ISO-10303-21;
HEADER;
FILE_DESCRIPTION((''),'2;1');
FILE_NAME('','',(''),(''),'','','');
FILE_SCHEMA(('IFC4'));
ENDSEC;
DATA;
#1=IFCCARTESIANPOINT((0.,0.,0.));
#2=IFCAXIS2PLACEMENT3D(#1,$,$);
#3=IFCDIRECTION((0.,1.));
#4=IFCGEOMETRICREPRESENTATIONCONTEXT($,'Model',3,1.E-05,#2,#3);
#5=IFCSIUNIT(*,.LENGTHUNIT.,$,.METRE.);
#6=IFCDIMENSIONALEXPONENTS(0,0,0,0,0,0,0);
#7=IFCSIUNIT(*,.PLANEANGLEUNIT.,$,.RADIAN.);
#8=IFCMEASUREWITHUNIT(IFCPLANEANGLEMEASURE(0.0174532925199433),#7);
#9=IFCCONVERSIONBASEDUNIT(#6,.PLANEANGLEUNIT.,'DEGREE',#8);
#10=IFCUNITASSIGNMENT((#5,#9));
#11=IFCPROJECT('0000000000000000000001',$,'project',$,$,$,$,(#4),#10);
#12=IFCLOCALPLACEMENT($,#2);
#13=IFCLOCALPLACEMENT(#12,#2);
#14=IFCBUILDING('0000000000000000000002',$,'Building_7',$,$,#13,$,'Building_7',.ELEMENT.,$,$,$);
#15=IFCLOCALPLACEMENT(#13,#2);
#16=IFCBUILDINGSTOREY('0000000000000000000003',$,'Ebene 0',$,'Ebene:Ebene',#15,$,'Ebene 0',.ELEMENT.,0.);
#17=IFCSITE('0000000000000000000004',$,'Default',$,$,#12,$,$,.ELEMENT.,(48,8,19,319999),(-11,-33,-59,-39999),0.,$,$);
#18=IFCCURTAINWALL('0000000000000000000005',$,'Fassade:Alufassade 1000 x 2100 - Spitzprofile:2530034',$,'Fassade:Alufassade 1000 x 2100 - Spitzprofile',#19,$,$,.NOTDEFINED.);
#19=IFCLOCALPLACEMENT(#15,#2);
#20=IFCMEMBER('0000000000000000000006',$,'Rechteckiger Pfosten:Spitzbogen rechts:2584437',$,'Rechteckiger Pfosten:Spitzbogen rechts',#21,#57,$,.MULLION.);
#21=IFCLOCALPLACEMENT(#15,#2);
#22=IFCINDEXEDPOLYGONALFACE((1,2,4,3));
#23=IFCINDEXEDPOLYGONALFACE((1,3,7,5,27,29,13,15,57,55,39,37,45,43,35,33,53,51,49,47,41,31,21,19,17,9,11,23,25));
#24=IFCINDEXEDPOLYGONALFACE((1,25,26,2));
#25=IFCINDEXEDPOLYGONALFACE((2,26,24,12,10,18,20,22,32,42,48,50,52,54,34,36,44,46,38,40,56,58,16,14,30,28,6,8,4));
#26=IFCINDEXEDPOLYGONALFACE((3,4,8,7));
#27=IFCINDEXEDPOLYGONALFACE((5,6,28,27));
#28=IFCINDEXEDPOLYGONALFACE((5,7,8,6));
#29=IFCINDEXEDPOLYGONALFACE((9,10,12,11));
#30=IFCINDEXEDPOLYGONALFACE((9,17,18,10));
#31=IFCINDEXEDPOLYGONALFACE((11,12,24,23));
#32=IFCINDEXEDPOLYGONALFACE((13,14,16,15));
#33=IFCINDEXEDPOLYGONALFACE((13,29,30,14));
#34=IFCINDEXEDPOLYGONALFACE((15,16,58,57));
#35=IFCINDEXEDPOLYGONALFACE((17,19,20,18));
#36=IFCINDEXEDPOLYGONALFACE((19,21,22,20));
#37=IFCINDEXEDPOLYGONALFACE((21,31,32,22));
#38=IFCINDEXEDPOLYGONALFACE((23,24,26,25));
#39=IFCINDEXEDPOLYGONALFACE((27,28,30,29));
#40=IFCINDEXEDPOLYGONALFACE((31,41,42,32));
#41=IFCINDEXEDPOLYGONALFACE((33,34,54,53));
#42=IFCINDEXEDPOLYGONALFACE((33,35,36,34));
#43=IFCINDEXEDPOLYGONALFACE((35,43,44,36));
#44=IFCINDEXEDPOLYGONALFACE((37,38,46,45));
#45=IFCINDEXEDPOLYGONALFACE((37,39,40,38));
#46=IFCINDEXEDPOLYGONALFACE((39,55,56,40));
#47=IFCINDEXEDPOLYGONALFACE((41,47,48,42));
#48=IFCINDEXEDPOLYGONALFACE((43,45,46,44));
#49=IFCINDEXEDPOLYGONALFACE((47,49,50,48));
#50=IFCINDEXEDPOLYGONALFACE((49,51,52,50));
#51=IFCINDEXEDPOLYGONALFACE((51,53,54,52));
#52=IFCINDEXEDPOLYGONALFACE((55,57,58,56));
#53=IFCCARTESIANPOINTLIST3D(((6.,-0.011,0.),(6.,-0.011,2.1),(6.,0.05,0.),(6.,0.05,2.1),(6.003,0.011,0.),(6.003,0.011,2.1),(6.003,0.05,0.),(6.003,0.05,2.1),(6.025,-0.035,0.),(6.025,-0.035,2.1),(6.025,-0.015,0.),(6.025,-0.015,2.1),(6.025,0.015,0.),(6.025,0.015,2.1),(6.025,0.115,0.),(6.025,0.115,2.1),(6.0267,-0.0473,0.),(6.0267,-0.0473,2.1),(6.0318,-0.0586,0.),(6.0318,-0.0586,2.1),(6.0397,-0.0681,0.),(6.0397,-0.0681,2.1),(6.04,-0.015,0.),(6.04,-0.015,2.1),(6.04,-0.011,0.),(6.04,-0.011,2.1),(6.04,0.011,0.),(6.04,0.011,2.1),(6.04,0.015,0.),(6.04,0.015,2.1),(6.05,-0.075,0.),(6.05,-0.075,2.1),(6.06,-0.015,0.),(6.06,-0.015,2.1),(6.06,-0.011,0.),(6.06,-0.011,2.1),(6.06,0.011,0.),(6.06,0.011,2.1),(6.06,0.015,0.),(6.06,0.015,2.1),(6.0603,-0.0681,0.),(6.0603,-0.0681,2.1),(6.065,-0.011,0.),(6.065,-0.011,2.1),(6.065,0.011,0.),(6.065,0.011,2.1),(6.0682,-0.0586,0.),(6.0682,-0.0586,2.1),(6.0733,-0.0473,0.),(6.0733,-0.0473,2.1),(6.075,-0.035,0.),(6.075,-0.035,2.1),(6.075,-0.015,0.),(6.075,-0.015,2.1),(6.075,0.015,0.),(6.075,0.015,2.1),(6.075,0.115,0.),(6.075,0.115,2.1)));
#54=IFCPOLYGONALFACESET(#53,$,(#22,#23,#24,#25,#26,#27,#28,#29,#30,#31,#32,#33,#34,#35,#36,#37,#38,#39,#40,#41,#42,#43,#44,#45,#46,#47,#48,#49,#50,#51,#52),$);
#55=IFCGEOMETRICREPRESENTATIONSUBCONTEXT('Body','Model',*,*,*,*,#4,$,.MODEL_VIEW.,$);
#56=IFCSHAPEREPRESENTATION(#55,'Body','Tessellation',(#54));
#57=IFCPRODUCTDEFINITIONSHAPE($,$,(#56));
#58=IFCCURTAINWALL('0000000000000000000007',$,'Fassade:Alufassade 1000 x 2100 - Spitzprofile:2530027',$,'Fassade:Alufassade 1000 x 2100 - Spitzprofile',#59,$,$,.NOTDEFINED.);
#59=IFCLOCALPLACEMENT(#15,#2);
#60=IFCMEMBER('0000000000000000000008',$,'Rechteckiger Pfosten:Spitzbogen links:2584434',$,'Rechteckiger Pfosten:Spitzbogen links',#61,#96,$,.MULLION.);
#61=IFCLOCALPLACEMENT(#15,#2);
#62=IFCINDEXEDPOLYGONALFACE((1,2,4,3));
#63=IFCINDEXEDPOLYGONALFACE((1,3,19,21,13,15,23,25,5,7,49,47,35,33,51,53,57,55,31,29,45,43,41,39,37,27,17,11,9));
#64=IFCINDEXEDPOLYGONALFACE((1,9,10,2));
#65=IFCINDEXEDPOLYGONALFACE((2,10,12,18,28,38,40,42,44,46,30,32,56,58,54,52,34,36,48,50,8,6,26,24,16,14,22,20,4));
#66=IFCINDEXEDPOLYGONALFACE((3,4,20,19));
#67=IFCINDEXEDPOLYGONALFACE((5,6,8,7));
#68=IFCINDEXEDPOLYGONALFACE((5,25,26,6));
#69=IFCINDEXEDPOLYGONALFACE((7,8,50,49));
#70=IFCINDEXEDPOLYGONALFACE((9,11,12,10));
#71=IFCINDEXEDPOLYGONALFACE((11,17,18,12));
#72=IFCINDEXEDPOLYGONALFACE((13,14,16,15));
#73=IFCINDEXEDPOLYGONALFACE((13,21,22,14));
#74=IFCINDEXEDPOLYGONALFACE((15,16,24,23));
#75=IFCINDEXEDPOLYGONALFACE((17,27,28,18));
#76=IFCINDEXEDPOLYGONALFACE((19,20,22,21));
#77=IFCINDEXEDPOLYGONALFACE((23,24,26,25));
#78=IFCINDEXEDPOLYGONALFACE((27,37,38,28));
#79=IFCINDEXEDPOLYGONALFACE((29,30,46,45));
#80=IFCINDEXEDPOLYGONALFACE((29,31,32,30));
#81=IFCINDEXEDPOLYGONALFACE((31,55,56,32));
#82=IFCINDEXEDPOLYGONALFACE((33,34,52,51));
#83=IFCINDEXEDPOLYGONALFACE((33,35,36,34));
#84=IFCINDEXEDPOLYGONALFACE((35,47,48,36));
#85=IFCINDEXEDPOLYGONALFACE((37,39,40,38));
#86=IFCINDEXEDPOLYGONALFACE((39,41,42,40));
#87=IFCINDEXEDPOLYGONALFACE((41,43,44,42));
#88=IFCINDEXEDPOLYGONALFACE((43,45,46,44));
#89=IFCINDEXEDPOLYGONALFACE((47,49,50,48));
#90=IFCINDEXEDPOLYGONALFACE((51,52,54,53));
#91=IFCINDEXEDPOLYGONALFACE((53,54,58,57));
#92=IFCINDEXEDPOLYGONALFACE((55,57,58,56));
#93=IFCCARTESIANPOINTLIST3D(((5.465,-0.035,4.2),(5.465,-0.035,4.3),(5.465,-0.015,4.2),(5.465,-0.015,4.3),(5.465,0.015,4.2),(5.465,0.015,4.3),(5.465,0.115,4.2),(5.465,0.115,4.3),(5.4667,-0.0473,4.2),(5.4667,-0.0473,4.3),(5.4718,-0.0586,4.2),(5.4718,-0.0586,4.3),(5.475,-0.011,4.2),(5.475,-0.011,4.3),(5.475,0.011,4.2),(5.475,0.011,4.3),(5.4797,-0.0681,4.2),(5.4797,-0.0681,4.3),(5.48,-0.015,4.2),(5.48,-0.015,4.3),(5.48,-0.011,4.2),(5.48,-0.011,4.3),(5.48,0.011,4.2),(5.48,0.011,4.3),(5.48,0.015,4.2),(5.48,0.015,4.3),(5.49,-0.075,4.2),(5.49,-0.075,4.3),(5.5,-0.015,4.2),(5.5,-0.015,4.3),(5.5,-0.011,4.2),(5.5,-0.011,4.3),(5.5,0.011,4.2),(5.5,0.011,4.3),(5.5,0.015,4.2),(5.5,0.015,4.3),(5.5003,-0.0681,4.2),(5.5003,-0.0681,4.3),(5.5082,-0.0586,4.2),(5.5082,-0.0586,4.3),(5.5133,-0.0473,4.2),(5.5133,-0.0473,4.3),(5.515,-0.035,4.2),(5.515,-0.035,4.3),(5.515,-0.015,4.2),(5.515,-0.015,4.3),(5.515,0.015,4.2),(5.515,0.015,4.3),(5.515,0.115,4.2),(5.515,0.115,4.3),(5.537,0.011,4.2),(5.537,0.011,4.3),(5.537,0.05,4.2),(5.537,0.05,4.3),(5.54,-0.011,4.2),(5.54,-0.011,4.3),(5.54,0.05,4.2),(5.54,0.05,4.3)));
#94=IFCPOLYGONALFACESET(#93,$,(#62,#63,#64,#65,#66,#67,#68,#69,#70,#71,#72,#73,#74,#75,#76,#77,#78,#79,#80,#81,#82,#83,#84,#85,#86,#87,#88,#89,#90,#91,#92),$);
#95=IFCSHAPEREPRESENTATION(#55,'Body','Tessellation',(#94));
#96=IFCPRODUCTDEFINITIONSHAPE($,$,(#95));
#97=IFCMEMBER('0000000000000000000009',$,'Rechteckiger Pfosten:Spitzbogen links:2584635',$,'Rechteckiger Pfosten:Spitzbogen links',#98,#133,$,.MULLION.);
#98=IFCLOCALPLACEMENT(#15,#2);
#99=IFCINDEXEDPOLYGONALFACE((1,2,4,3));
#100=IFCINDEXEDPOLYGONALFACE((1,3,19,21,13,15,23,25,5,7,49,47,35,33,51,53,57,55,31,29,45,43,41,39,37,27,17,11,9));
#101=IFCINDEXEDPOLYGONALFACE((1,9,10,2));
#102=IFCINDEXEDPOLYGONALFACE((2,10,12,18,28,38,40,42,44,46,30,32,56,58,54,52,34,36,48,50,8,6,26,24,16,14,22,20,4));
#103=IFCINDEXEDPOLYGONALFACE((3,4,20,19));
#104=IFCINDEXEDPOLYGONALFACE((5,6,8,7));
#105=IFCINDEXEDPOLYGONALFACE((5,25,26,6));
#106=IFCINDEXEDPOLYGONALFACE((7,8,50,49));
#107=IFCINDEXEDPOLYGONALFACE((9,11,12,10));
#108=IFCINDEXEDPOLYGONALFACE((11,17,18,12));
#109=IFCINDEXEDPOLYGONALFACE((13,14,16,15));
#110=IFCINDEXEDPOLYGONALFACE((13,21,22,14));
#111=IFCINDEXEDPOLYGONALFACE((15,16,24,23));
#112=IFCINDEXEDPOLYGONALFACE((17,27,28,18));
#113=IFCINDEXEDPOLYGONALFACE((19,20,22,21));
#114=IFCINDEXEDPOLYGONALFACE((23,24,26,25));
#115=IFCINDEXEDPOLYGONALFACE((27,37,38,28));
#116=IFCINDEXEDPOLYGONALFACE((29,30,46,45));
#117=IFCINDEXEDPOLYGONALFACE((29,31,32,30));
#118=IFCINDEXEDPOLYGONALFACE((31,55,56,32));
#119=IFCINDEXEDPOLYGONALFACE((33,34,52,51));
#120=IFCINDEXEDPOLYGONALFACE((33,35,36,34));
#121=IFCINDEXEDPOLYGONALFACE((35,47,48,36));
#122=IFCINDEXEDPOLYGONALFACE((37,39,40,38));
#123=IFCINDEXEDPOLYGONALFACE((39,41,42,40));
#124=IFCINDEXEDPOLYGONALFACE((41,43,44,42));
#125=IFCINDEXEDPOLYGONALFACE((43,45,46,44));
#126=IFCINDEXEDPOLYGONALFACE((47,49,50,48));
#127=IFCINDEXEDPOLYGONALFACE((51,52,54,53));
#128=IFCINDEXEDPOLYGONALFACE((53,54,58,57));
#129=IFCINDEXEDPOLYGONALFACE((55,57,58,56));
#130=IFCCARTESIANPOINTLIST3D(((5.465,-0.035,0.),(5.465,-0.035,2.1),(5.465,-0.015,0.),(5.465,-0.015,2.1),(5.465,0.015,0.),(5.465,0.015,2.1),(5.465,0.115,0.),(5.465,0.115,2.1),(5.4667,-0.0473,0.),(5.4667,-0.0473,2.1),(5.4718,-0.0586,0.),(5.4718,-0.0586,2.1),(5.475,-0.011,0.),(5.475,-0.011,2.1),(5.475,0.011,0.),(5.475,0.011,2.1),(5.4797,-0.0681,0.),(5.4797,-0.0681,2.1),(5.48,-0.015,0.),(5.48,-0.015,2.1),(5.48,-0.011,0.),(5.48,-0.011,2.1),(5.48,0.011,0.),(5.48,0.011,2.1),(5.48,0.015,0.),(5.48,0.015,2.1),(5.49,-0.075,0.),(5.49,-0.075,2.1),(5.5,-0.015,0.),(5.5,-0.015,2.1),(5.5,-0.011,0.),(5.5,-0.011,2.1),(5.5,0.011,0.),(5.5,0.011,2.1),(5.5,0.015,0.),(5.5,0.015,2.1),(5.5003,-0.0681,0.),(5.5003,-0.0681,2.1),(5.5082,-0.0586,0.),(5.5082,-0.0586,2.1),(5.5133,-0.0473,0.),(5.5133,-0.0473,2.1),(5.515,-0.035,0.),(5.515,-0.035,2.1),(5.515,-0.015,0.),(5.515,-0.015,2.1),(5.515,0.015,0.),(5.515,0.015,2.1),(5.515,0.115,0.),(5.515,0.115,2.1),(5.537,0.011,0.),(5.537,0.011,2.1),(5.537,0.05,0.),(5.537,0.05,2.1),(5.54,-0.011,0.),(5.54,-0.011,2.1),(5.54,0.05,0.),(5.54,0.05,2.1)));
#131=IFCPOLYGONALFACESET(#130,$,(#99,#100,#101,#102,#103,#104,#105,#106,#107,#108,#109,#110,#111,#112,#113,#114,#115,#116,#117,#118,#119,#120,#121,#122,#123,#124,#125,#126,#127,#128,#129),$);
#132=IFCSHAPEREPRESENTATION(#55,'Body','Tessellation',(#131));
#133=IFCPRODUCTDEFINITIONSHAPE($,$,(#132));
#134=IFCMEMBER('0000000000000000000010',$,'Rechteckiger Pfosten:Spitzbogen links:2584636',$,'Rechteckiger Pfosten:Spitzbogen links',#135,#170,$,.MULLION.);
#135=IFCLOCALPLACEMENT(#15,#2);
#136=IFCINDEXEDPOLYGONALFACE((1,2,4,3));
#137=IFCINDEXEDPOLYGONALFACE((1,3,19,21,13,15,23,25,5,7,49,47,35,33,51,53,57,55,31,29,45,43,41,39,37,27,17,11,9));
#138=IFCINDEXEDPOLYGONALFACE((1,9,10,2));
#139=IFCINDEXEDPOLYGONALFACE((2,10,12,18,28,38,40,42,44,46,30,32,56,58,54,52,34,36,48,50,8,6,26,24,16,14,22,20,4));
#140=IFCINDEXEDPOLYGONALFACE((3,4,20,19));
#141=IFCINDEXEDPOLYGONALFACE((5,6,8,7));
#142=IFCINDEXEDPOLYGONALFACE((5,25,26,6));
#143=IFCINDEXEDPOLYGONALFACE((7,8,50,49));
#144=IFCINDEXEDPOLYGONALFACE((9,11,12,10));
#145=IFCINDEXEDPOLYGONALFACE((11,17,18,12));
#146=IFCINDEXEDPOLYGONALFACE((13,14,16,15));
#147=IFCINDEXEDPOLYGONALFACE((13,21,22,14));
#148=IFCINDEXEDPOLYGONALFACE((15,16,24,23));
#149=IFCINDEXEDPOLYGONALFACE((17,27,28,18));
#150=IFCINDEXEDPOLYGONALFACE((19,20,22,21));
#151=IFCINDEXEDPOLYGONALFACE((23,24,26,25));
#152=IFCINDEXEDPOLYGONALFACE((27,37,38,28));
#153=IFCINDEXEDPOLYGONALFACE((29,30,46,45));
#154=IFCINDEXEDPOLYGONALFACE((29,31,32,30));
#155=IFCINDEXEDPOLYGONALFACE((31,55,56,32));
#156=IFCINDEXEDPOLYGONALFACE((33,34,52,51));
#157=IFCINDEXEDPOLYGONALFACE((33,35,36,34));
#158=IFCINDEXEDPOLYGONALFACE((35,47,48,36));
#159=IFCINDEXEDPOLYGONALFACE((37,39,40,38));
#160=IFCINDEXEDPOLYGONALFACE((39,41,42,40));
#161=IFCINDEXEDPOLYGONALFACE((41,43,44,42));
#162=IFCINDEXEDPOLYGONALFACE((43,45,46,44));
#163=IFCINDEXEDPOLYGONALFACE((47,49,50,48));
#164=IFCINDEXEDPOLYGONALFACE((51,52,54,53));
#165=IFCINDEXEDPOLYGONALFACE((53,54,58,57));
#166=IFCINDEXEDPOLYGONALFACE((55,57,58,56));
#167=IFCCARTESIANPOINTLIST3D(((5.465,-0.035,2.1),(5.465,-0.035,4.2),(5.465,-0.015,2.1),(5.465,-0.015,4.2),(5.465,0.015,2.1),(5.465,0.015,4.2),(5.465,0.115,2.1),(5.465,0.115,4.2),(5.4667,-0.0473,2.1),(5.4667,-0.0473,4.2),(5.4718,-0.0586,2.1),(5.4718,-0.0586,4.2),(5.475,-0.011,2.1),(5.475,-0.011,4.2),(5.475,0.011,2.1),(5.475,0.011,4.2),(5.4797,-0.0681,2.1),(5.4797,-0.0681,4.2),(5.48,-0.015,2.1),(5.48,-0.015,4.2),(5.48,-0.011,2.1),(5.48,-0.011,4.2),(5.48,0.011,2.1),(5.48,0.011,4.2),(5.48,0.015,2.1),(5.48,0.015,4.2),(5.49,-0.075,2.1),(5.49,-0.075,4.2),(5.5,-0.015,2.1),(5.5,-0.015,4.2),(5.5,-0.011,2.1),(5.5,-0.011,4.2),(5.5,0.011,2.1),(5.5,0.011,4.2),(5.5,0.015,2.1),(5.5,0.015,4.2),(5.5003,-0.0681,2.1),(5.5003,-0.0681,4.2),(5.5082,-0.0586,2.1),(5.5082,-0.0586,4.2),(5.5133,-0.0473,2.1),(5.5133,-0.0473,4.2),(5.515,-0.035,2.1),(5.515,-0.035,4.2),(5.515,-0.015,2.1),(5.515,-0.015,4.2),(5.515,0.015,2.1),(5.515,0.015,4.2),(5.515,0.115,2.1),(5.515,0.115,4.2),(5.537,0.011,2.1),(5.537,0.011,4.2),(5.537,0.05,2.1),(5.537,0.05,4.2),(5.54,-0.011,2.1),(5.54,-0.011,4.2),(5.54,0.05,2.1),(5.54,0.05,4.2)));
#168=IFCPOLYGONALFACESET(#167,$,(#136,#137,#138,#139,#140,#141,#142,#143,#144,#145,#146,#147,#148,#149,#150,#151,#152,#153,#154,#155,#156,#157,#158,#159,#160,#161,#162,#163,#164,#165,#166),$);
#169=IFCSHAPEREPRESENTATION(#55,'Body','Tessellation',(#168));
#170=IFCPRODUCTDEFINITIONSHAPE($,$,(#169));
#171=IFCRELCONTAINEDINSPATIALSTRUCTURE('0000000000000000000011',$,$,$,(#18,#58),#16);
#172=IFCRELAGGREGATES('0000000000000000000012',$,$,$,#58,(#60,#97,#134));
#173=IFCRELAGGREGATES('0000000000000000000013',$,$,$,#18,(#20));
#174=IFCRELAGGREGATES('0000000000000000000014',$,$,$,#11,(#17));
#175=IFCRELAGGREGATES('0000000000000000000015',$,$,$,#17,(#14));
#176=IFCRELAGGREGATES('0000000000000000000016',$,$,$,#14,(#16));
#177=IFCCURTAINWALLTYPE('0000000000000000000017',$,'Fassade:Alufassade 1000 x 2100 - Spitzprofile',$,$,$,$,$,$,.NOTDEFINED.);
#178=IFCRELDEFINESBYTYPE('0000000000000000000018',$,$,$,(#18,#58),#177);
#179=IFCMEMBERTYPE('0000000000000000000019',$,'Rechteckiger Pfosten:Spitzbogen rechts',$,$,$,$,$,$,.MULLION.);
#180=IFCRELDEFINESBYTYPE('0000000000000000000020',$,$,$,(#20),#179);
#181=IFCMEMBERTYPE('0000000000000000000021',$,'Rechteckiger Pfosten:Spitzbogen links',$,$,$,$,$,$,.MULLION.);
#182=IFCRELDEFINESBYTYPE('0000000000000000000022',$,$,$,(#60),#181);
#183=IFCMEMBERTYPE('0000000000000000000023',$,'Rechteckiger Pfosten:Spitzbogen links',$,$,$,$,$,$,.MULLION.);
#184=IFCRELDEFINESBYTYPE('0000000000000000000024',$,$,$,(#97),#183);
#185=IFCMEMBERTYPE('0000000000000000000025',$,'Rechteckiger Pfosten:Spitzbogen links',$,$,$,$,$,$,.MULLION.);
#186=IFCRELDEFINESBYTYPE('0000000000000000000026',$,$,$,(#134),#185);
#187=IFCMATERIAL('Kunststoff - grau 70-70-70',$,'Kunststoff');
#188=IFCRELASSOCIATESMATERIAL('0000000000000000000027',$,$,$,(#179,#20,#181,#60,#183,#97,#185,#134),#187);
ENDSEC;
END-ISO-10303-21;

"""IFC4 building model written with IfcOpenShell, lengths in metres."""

from ifc_helpers import new_model, entity, si_unit, converted_unit, direction, frame, origin, place, context, subcontext, project, spatial, line, arc, indexed_curve, outline, extrude, source, transform, mapped, material, type_object, type_shapes, element, aggregate, save


model = new_model("IFC4")

# Units and contexts
model_context = context("Model", 3, precision=1e-05, world=origin(), true_north=direction((0.0, 1.0)))
body_context = subcontext(model_context, "Body", "Model", "MODEL_VIEW")
ifc_project = project(units=[si_unit("LENGTHUNIT", "METRE"), converted_unit("PLANEANGLEUNIT", "DEGREE", entity("IfcPlaneAngleMeasure", 0.0174532925199433), si_unit("PLANEANGLEUNIT", "RADIAN"), dimensions=[0, 0, 0, 0, 0, 0, 0])], contexts=[model_context])

# Site, building, storey
site_placement = place(None, origin())
site = spatial("IfcSite", under=ifc_project, at=site_placement, Name="Default", CompositionType="ELEMENT", RefLatitude=(48, 8, 19, 319999), RefLongitude=(-11, -33, -59, -39999), RefElevation=0.0)
building_placement = place(site_placement, origin())
building = spatial("IfcBuilding", under=site, at=building_placement, Name="Building_7", LongName="Building_7", CompositionType="ELEMENT")
storey_placement = place(building_placement, origin())
storey = spatial("IfcBuildingStorey", under=building, at=storey_placement, Name="Ebene 0", ObjectType="Ebene:Ebene", LongName="Ebene 0", CompositionType="ELEMENT", Elevation=0.0)

# Curtain wall, member
curtain_wall_type = type_object("IfcCurtainWallType", Name="Fassade:Alufassade 1000 x 2100 - Spitzprofile", PredefinedType="NOTDEFINED")
curtain_wall_1_placement = place(storey_placement, origin())
curtain_wall_1 = element("IfcCurtainWall", 1, at=curtain_wall_1_placement, inside=storey, type_object=curtain_wall_type, Name="Fassade:Alufassade 1000 x 2100 - Spitzprofile:2530034", ObjectType="Fassade:Alufassade 1000 x 2100 - Spitzprofile", PredefinedType="NOTDEFINED")
ifc_material_1 = material(Name="Kunststoff - grau 70-70-70", Category="Kunststoff")
member_type_1 = type_object("IfcMemberType", Name="Rechteckiger Pfosten:Spitzbogen rechts", PredefinedType="MULLION", material=ifc_material_1)
shared_shape_1 = source(origin(), body_context, "Body", "SweptSolid", [
    extrude(outline(indexed_curve([(-0.107, -0.0321), (-0.007, -0.0321), (-0.007, -0.0171), (-0.003, -0.0171), (-0.003, -0.0221), (0.019, -0.0221), (0.019, -0.0171), (0.023, -0.0171), (0.023, -0.0321), (0.043, -0.0321), (0.0666, -0.0254), (0.083, -0.0071), (0.0666, 0.0111), (0.043, 0.0179), (0.023, 0.0179), (0.023, 0.0029), (0.019, 0.0029), (0.019, 0.0429), (-0.042, 0.0429), (-0.042, 0.0399), (-0.003, 0.0399), (-0.003, 0.0029), (-0.007, 0.0029), (-0.007, 0.0179), (-0.107, 0.0179)], segments=[line(1, 2, 3, 4, 5, 6, 7, 8, 9, 10), arc(10, 11, 12), arc(12, 13, 14), line(14, 15, 16, 17, 18, 19, 20, 21, 22, 23, 24, 25, 1)], self_intersect=False)), frame((-0.0429, 0.008, -2.1), z_axis=(0.0, 0.0, 1.0), x_axis=(0.0, -1.0, 0.0)), (0.0, 0.0, 1.0), 2.1),
])
type_shapes(member_type_1, [shared_shape_1])
member_1_placement = place(curtain_wall_1_placement, frame((6.0, 0.0, 0.0), z_axis=(0.0, 0.0, -1.0), x_axis=(-1.0, 0.0, 0.0)))
member_1 = element("IfcMember", 2, at=member_1_placement, type_object=member_type_1, material=ifc_material_1, Name="Rechteckiger Pfosten:Spitzbogen rechts:2584437", ObjectType="Rechteckiger Pfosten:Spitzbogen rechts", PredefinedType="MULLION", context=body_context, shape_type="MappedRepresentation", body=[
    mapped(shared_shape_1, transform((0.0, 0.0, 0.0), scale=1.0)),
])

# Curtain wall, members
curtain_wall_2_placement = place(storey_placement, origin())
curtain_wall_2 = element("IfcCurtainWall", 3, at=curtain_wall_2_placement, inside=storey, type_object=curtain_wall_type, Name="Fassade:Alufassade 1000 x 2100 - Spitzprofile:2530027", ObjectType="Fassade:Alufassade 1000 x 2100 - Spitzprofile", PredefinedType="NOTDEFINED")
member_type_2 = type_object("IfcMemberType", Name="Rechteckiger Pfosten:Spitzbogen links", PredefinedType="MULLION", material=ifc_material_1)
shared_shape_2 = source(origin(), body_context, "Body", "SweptSolid", [
    extrude(outline(indexed_curve([(-0.107, -0.0321), (-0.007, -0.0321), (-0.007, -0.0171), (-0.003, -0.0171), (-0.003, -0.0221), (0.019, -0.0221), (0.019, -0.0171), (0.023, -0.0171), (0.023, -0.0321), (0.043, -0.0321), (0.0666, -0.0254), (0.083, -0.0071), (0.0666, 0.0111), (0.043, 0.0179), (0.023, 0.0179), (0.023, 0.0029), (0.019, 0.0029), (0.019, 0.0429), (-0.042, 0.0429), (-0.042, 0.0399), (-0.003, 0.0399), (-0.003, 0.0029), (-0.007, 0.0029), (-0.007, 0.0179), (-0.107, 0.0179)], segments=[line(1, 2, 3, 4, 5, 6, 7, 8, 9, 10), arc(10, 11, 12), arc(12, 13, 14), line(14, 15, 16, 17, 18, 19, 20, 21, 22, 23, 24, 25, 1)], self_intersect=False)), frame((-0.0429, 0.008, -0.1), z_axis=(0.0, 0.0, 1.0), x_axis=(0.0, -1.0, 0.0)), (0.0, 0.0, 1.0), 0.1),
])
type_shapes(member_type_2, [shared_shape_2])
member_2_placement = place(curtain_wall_2_placement, frame((5.54, 0.0, 4.3)))
member_2 = element("IfcMember", 4, at=member_2_placement, type_object=member_type_2, material=ifc_material_1, Name="Rechteckiger Pfosten:Spitzbogen links:2584434", ObjectType="Rechteckiger Pfosten:Spitzbogen links", PredefinedType="MULLION", context=body_context, shape_type="MappedRepresentation", body=[
    mapped(shared_shape_2, transform((0.0, 0.0, 0.0), scale=1.0)),
])
member_type_3 = type_object("IfcMemberType", Name="Rechteckiger Pfosten:Spitzbogen links", PredefinedType="MULLION", material=ifc_material_1)
shared_shape_3 = source(origin(), body_context, "Body", "SweptSolid", [
    extrude(outline(indexed_curve([(-0.107, -0.0321), (-0.007, -0.0321), (-0.007, -0.0171), (-0.003, -0.0171), (-0.003, -0.0221), (0.019, -0.0221), (0.019, -0.0171), (0.023, -0.0171), (0.023, -0.0321), (0.043, -0.0321), (0.0666, -0.0254), (0.083, -0.0071), (0.0666, 0.0111), (0.043, 0.0179), (0.023, 0.0179), (0.023, 0.0029), (0.019, 0.0029), (0.019, 0.0429), (-0.042, 0.0429), (-0.042, 0.0399), (-0.003, 0.0399), (-0.003, 0.0029), (-0.007, 0.0029), (-0.007, 0.0179), (-0.107, 0.0179)], segments=[line(1, 2, 3, 4, 5, 6, 7, 8, 9, 10), arc(10, 11, 12), arc(12, 13, 14), line(14, 15, 16, 17, 18, 19, 20, 21, 22, 23, 24, 25, 1)], self_intersect=False)), frame((-0.0429, 0.008, -2.1), z_axis=(0.0, 0.0, 1.0), x_axis=(0.0, -1.0, 0.0)), (0.0, 0.0, 1.0), 2.1),
])
type_shapes(member_type_3, [shared_shape_3])
member_3_placement = place(curtain_wall_2_placement, frame((5.54, 0.0, 2.1)))
member_3 = element("IfcMember", 5, at=member_3_placement, type_object=member_type_3, material=ifc_material_1, Name="Rechteckiger Pfosten:Spitzbogen links:2584635", ObjectType="Rechteckiger Pfosten:Spitzbogen links", PredefinedType="MULLION", context=body_context, shape_type="MappedRepresentation", body=[
    mapped(shared_shape_3, transform((0.0, 0.0, 0.0), scale=1.0)),
])
member_type_4 = type_object("IfcMemberType", Name="Rechteckiger Pfosten:Spitzbogen links", PredefinedType="MULLION", material=ifc_material_1)
shared_shape_4 = source(origin(), body_context, "Body", "SweptSolid", [
    extrude(outline(indexed_curve([(-0.107, -0.0321), (-0.007, -0.0321), (-0.007, -0.0171), (-0.003, -0.0171), (-0.003, -0.0221), (0.019, -0.0221), (0.019, -0.0171), (0.023, -0.0171), (0.023, -0.0321), (0.043, -0.0321), (0.0666, -0.0254), (0.083, -0.0071), (0.0666, 0.0111), (0.043, 0.0179), (0.023, 0.0179), (0.023, 0.0029), (0.019, 0.0029), (0.019, 0.0429), (-0.042, 0.0429), (-0.042, 0.0399), (-0.003, 0.0399), (-0.003, 0.0029), (-0.007, 0.0029), (-0.007, 0.0179), (-0.107, 0.0179)], segments=[line(1, 2, 3, 4, 5, 6, 7, 8, 9, 10), arc(10, 11, 12), arc(12, 13, 14), line(14, 15, 16, 17, 18, 19, 20, 21, 22, 23, 24, 25, 1)], self_intersect=False)), frame((-0.0429, 0.008, -2.1), z_axis=(0.0, 0.0, 1.0), x_axis=(0.0, -1.0, 0.0)), (0.0, 0.0, 1.0), 2.1),
])
type_shapes(member_type_4, [shared_shape_4])
member_4_placement = place(curtain_wall_2_placement, frame((5.54, 0.0, 4.2)))
member_4 = element("IfcMember", 6, at=member_4_placement, type_object=member_type_4, material=ifc_material_1, Name="Rechteckiger Pfosten:Spitzbogen links:2584636", ObjectType="Rechteckiger Pfosten:Spitzbogen links", PredefinedType="MULLION", context=body_context, shape_type="MappedRepresentation", body=[
    mapped(shared_shape_4, transform((0.0, 0.0, 0.0), scale=1.0)),
])
aggregate(curtain_wall_2, [member_2, member_3, member_4])

aggregate(curtain_wall_1, [member_1])

save(model, "model.ifc")
